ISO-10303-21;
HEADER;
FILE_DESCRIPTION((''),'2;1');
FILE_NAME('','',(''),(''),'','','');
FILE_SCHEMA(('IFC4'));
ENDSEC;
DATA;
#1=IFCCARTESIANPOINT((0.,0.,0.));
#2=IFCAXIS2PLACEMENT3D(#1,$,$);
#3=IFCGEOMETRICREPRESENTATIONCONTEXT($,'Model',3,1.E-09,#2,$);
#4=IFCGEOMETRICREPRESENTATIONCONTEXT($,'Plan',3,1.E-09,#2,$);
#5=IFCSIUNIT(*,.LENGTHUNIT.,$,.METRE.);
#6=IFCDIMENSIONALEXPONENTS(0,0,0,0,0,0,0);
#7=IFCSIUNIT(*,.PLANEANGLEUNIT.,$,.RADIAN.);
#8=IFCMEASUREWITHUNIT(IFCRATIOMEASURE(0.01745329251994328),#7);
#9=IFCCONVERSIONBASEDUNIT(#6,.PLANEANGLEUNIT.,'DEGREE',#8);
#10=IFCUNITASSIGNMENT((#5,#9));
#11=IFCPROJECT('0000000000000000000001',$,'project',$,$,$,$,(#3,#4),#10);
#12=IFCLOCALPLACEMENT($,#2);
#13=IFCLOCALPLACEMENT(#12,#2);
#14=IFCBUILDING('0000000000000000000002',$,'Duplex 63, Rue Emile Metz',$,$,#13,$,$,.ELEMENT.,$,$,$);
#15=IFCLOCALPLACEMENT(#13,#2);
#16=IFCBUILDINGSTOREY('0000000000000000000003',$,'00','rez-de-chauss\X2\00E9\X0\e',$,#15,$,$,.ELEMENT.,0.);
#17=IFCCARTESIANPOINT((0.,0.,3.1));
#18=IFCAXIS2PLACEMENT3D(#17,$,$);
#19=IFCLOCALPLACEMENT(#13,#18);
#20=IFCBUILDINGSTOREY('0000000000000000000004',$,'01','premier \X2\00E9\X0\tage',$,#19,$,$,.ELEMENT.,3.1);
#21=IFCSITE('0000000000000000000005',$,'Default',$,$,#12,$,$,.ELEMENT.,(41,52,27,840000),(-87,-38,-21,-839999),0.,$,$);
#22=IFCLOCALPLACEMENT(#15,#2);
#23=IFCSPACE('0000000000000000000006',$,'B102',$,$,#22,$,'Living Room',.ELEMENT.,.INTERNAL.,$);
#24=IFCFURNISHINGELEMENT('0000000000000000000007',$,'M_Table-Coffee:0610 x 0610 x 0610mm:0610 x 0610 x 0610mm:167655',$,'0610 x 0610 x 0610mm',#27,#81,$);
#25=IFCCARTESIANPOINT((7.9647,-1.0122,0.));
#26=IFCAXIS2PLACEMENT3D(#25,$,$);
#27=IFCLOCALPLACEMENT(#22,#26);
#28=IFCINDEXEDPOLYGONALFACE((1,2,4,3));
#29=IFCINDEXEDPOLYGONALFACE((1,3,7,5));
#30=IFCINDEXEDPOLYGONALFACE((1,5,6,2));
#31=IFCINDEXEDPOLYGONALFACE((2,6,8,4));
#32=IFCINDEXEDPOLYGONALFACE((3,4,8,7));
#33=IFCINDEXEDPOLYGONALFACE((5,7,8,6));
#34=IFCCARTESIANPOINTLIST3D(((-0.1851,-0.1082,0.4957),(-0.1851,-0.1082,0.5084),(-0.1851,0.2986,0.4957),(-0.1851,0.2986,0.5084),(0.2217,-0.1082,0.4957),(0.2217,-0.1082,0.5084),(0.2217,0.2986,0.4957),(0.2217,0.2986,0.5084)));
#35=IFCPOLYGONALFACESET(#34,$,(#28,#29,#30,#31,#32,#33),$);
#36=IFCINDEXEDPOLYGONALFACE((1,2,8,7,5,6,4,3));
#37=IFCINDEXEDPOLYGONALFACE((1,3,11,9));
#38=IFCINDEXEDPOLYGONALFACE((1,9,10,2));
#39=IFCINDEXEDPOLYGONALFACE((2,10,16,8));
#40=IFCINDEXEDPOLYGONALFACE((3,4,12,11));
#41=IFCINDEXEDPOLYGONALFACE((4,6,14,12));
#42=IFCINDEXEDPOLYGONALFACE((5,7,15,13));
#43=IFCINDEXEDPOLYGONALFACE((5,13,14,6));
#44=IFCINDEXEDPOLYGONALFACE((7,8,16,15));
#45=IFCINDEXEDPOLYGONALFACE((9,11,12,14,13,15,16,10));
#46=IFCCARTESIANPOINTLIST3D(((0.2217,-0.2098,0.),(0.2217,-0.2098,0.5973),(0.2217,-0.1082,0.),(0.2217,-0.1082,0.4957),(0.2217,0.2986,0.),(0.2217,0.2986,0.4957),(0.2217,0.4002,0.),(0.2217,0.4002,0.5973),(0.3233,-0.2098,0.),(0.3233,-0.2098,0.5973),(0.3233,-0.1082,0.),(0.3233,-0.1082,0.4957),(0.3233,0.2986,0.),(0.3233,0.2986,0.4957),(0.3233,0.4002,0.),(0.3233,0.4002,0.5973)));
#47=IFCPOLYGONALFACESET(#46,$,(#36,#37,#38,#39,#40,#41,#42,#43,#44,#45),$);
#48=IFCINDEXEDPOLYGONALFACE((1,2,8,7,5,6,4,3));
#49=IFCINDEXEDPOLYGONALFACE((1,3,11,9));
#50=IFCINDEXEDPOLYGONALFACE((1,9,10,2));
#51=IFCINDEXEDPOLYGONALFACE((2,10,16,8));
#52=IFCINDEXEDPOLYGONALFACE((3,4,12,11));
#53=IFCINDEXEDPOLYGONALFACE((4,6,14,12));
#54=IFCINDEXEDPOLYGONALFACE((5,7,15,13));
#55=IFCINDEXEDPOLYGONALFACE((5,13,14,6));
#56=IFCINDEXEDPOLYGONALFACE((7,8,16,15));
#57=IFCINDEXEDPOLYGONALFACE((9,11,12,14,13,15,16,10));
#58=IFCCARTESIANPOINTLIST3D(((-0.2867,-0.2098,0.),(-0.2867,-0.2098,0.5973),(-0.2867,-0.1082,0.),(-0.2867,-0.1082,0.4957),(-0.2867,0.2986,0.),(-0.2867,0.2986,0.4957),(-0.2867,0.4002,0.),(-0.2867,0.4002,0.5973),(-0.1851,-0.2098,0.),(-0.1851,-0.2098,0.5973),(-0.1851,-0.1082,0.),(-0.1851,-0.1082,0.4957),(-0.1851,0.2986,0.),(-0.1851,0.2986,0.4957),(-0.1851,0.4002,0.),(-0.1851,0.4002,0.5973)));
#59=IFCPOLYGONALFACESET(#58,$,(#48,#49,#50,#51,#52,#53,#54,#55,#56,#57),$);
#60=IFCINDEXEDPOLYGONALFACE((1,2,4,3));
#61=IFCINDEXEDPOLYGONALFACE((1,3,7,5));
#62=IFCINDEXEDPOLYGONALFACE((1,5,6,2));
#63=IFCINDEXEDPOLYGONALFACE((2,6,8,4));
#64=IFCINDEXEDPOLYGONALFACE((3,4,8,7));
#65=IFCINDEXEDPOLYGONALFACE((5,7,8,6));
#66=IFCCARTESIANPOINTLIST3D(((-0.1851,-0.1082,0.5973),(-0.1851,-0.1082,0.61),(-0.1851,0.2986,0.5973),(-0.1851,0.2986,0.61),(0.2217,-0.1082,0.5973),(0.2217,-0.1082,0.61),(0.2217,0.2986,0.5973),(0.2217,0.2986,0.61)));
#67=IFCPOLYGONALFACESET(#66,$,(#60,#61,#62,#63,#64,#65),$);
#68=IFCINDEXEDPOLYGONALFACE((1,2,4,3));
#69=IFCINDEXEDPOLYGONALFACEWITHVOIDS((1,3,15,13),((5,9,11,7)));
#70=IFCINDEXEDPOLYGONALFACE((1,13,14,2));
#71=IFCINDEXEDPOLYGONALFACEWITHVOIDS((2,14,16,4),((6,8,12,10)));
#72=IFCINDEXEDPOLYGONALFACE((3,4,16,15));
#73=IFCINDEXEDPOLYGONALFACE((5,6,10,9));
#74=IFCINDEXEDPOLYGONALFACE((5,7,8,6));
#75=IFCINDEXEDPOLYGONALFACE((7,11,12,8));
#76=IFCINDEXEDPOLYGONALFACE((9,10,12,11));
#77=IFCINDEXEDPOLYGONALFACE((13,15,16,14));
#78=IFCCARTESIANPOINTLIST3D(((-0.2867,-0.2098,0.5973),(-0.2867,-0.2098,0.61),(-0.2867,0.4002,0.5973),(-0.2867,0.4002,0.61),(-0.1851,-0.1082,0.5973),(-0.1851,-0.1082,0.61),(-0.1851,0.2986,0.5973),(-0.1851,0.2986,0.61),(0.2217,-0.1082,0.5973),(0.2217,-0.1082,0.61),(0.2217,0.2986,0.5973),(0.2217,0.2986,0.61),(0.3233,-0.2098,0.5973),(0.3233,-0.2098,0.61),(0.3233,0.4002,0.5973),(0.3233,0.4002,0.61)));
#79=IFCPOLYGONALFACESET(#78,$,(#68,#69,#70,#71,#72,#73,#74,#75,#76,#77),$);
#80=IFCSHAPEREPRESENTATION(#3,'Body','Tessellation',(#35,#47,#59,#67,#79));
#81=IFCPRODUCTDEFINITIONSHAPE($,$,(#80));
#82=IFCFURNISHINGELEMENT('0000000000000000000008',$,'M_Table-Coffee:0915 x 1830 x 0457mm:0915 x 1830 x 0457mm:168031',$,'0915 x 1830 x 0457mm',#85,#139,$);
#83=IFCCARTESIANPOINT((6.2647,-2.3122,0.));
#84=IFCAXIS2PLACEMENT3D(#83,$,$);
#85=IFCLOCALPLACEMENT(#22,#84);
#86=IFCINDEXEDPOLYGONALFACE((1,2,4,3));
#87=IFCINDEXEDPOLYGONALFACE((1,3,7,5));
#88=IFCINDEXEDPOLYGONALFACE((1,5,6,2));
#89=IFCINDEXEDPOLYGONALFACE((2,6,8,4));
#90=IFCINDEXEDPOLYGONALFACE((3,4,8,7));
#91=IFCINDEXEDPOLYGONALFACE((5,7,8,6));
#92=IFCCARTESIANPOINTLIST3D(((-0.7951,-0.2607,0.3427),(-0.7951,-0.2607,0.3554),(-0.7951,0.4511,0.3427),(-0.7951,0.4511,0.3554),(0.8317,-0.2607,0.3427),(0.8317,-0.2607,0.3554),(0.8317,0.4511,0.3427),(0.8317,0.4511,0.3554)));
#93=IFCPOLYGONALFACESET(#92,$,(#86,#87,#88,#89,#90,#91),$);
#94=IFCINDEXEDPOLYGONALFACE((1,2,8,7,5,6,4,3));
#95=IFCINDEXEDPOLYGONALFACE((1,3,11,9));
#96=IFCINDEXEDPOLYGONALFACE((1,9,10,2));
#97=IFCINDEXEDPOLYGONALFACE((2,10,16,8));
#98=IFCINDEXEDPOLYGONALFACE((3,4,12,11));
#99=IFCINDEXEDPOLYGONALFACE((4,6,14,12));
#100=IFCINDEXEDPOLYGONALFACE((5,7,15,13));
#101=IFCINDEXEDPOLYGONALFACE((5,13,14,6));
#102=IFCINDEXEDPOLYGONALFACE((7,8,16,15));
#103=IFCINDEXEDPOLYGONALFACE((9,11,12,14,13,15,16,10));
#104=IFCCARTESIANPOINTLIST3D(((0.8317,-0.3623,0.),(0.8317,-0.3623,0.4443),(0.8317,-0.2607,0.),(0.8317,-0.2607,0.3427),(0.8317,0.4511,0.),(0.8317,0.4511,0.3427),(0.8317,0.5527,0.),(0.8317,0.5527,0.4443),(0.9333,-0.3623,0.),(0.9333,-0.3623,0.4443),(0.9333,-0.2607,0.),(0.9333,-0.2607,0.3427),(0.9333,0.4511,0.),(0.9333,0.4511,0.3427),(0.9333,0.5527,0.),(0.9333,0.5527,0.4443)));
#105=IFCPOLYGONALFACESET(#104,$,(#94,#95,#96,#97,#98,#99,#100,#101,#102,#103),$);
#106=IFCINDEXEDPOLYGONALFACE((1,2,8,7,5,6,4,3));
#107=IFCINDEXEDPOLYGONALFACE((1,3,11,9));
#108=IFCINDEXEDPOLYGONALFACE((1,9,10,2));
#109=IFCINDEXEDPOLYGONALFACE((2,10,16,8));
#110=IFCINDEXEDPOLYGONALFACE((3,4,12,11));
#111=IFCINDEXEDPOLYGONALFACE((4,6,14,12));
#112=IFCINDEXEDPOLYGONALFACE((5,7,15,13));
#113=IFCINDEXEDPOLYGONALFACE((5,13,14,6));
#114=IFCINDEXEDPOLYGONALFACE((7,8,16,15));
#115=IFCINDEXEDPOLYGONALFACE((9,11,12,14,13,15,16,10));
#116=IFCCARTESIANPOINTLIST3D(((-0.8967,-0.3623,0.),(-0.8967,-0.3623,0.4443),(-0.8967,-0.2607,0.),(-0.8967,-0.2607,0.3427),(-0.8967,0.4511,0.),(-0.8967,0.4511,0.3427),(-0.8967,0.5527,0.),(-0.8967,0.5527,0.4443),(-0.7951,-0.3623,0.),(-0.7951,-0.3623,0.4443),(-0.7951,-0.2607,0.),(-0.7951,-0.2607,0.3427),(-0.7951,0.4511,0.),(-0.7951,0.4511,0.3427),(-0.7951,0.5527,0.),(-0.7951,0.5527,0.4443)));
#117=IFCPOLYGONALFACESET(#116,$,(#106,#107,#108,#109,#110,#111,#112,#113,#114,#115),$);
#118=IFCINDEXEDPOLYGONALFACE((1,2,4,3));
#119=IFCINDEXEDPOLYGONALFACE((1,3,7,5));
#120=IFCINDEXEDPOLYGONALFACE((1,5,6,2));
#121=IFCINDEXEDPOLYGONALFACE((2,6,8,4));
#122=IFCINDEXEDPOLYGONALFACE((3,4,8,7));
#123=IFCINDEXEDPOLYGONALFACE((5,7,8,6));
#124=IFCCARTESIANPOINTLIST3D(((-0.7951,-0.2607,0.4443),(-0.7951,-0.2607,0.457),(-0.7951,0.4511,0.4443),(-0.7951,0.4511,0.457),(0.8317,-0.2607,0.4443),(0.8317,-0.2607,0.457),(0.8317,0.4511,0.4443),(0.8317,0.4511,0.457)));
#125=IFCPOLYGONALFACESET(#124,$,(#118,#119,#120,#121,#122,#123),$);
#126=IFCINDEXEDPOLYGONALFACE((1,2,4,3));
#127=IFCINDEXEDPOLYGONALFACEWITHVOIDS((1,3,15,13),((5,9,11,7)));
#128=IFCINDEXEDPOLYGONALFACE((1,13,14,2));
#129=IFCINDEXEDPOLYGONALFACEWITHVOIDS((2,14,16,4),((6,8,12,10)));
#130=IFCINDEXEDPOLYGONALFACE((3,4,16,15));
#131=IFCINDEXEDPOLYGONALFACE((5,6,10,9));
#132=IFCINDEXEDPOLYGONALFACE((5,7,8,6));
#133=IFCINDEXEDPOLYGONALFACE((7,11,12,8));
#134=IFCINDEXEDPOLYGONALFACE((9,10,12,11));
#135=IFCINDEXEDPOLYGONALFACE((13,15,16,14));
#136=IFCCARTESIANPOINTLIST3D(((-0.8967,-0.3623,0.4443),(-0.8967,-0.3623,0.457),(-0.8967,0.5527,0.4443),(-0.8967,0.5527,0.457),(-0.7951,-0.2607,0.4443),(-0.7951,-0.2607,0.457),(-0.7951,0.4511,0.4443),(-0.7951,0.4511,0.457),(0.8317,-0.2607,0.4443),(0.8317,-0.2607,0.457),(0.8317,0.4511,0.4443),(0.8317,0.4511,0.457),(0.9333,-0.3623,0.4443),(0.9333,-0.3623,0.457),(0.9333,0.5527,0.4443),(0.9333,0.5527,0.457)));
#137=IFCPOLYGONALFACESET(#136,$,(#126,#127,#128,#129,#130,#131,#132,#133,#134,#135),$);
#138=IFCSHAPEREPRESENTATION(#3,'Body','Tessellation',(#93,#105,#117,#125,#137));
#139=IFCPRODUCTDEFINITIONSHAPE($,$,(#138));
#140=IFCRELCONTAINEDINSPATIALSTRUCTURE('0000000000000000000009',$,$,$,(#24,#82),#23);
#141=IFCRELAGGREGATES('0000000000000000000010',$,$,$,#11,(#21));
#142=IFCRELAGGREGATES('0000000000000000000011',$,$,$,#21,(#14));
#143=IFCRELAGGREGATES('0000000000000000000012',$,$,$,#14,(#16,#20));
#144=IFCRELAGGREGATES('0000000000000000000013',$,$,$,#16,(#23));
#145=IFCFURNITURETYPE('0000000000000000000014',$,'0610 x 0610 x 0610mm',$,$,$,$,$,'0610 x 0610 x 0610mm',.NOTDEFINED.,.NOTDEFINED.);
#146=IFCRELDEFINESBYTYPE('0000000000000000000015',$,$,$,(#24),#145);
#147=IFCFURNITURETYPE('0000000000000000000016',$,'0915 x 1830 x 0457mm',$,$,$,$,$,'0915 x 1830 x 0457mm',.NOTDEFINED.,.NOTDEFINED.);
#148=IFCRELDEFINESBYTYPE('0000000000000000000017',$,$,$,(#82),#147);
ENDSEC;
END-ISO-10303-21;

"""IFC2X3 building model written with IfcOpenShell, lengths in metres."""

from ifc_helpers import new_model, entity, si_unit, converted_unit, frame, origin, origin_2d_with_axis, place, context, project, spatial, polyline, rectangle, outline, extrude, source, transform, mapped, type_object, type_shapes, element, save


model = new_model("IFC2X3")

# Units and contexts
model_context = context("Model", 3, precision=1e-09, world=origin())
plan_context = context("Plan", 3, precision=1e-09, world=origin())
ifc_project = project(units=[si_unit("LENGTHUNIT", "METRE"), converted_unit("PLANEANGLEUNIT", "DEGREE", entity("IfcRatioMeasure", 0.01745329251994328), si_unit("PLANEANGLEUNIT", "RADIAN"), dimensions=[0, 0, 0, 0, 0, 0, 0])], contexts=[model_context, plan_context])

# Site, building, storey
site_placement = place(None, origin())
site = spatial("IfcSite", under=ifc_project, at=site_placement, Name="Default", CompositionType="ELEMENT", RefLatitude=(41, 52, 27, 840000), RefLongitude=(-87, -38, -21, -839999), RefElevation=0.0)
building_placement = place(site_placement, origin())
building = spatial("IfcBuilding", under=site, at=building_placement, Name="Duplex 63, Rue Emile Metz", CompositionType="ELEMENT")
storey_1_placement = place(building_placement, origin())
storey_1 = spatial("IfcBuildingStorey", under=building, at=storey_1_placement, Name="00", Description="rez-de-chaussée", CompositionType="ELEMENT", Elevation=0.0)

# Shared definitions
storey_2_placement = place(building_placement, frame((0.0, 0.0, 3.1)))
storey_2 = spatial("IfcBuildingStorey", under=building, at=storey_2_placement, Name="01", Description="premier étage", CompositionType="ELEMENT", Elevation=3.1)

# Shared definitions
space_1_placement = place(storey_1_placement, origin())
space_1 = spatial("IfcSpace", under=storey_1, at=space_1_placement, Name="B102", LongName="Living Room", CompositionType="ELEMENT", InteriorOrExteriorSpace="INTERNAL")

# Furnishing element
furniture_type_1 = type_object("IfcFurnitureType", Name="0610 x 0610 x 0610mm", ElementType="0610 x 0610 x 0610mm", AssemblyPlace="NOTDEFINED")
shared_shape_1 = source(origin(), model_context, "Body", "SweptSolid", [
    extrude(rectangle(XDim=0.4068, YDim=0.4068, at=origin_2d_with_axis()), frame((0.0183, 0.0952, 0.4957), z_axis=(0.0, 0.0, 1.0), x_axis=(-1.0, 0.0, 0.0)), (0.0, 0.0, 1.0), 0.0127),
    extrude(outline(polyline([(-0.2732, -0.305), (0.324, -0.305), (0.324, 0.305), (-0.2732, 0.305), (-0.2732, 0.2034), (0.2225, 0.2034), (0.2225, -0.2034), (-0.2732, -0.2034), (-0.2732, -0.305)])), frame((0.2217, 0.0952, 0.2732), z_axis=(1.0, 0.0, 0.0), x_axis=(0.0, 0.0, 1.0)), (0.0, 0.0, 1.0), 0.1016),
    extrude(outline(polyline([(-0.305, -0.3241), (0.305, -0.3241), (0.305, 0.2733), (0.2034, 0.2733), (0.2034, -0.2224), (-0.2034, -0.2224), (-0.2034, 0.2733), (-0.305, 0.2733), (-0.305, -0.3241)])), frame((-0.2867, 0.0952, 0.2733), z_axis=(1.0, 0.0, 0.0), x_axis=(0.0, -1.0, 0.0)), (0.0, 0.0, 1.0), 0.1016),
    extrude(rectangle(XDim=0.4068, YDim=0.4068, at=origin_2d_with_axis()), frame((0.0183, 0.0952, 0.5973), z_axis=(0.0, 0.0, 1.0), x_axis=(-1.0, 0.0, 0.0)), (0.0, 0.0, 1.0), 0.0127),
    extrude(outline(polyline([(-0.305, -0.305), (0.305, -0.305), (0.305, 0.305), (-0.305, 0.305), (-0.305, -0.305)]), holes=[polyline([(-0.2034, -0.2034), (-0.2034, 0.2034), (0.2034, 0.2034), (0.2034, -0.2034), (-0.2034, -0.2034)])]), frame((0.0183, 0.0952, 0.5973), z_axis=(0.0, 0.0, 1.0), x_axis=(-1.0, 0.0, 0.0)), (0.0, 0.0, 1.0), 0.0127),
])
type_shapes(furniture_type_1, [shared_shape_1])
for number, where, name in (
    (1, (7.9647, -1.0122, 0.0), "M_Table-Coffee:0610 x 0610 x 0610mm:0610 x 0610 x 0610mm:167655"),
):
    element("IfcFurnishingElement", number, at=place(space_1_placement, frame(where)), inside=space_1, type_object=furniture_type_1, Name=name, ObjectType="0610 x 0610 x 0610mm", context=model_context, shape_type="MappedRepresentation", body=[
        mapped(shared_shape_1, transform((0.0, 0.0, 0.0), scale=1.0)),
    ])

# Furnishing element
furniture_type_2 = type_object("IfcFurnitureType", Name="0915 x 1830 x 0457mm", ElementType="0915 x 1830 x 0457mm", AssemblyPlace="NOTDEFINED")
shared_shape_2 = source(origin(), model_context, "Body", "SweptSolid", [
    extrude(rectangle(XDim=1.6268, YDim=0.7118, at=origin_2d_with_axis()), frame((0.0183, 0.0952, 0.3427), z_axis=(0.0, 0.0, 1.0), x_axis=(-1.0, 0.0, 0.0)), (0.0, 0.0, 1.0), 0.0127),
    extrude(outline(polyline([(-0.1967, -0.4575), (0.2475, -0.4575), (0.2475, 0.4575), (-0.1967, 0.4575), (-0.1967, 0.3559), (0.146, 0.3559), (0.146, -0.3559), (-0.1967, -0.3559), (-0.1967, -0.4575)])), frame((0.8317, 0.0952, 0.1967), z_axis=(1.0, 0.0, 0.0), x_axis=(0.0, 0.0, 1.0)), (0.0, 0.0, 1.0), 0.1016),
    extrude(outline(polyline([(-0.4575, -0.2476), (0.4575, -0.2476), (0.4575, 0.1968), (0.3559, 0.1968), (0.3559, -0.1459), (-0.3559, -0.1459), (-0.3559, 0.1968), (-0.4575, 0.1968), (-0.4575, -0.2476)])), frame((-0.8967, 0.0952, 0.1968), z_axis=(1.0, 0.0, 0.0), x_axis=(0.0, -1.0, 0.0)), (0.0, 0.0, 1.0), 0.1016),
    extrude(rectangle(XDim=1.6268, YDim=0.7118, at=origin_2d_with_axis()), frame((0.0183, 0.0952, 0.4443), z_axis=(0.0, 0.0, 1.0), x_axis=(-1.0, 0.0, 0.0)), (0.0, 0.0, 1.0), 0.0127),
    extrude(outline(polyline([(-0.915, -0.4575), (0.915, -0.4575), (0.915, 0.4575), (-0.915, 0.4575), (-0.915, -0.4575)]), holes=[polyline([(-0.8134, -0.3559), (-0.8134, 0.3559), (0.8134, 0.3559), (0.8134, -0.3559), (-0.8134, -0.3559)])]), frame((0.0183, 0.0952, 0.4443), z_axis=(0.0, 0.0, 1.0), x_axis=(-1.0, 0.0, 0.0)), (0.0, 0.0, 1.0), 0.0127),
])
type_shapes(furniture_type_2, [shared_shape_2])
furnishing_1_placement = place(space_1_placement, frame((6.2647, -2.3122, 0.0)))
element("IfcFurnishingElement", 2, at=furnishing_1_placement, inside=space_1, type_object=furniture_type_2, Name="M_Table-Coffee:0915 x 1830 x 0457mm:0915 x 1830 x 0457mm:168031", ObjectType="0915 x 1830 x 0457mm", context=model_context, shape_type="MappedRepresentation", body=[
    mapped(shared_shape_2, transform((0.0, 0.0, 0.0), scale=1.0)),
])

save(model, "model.ifc")
